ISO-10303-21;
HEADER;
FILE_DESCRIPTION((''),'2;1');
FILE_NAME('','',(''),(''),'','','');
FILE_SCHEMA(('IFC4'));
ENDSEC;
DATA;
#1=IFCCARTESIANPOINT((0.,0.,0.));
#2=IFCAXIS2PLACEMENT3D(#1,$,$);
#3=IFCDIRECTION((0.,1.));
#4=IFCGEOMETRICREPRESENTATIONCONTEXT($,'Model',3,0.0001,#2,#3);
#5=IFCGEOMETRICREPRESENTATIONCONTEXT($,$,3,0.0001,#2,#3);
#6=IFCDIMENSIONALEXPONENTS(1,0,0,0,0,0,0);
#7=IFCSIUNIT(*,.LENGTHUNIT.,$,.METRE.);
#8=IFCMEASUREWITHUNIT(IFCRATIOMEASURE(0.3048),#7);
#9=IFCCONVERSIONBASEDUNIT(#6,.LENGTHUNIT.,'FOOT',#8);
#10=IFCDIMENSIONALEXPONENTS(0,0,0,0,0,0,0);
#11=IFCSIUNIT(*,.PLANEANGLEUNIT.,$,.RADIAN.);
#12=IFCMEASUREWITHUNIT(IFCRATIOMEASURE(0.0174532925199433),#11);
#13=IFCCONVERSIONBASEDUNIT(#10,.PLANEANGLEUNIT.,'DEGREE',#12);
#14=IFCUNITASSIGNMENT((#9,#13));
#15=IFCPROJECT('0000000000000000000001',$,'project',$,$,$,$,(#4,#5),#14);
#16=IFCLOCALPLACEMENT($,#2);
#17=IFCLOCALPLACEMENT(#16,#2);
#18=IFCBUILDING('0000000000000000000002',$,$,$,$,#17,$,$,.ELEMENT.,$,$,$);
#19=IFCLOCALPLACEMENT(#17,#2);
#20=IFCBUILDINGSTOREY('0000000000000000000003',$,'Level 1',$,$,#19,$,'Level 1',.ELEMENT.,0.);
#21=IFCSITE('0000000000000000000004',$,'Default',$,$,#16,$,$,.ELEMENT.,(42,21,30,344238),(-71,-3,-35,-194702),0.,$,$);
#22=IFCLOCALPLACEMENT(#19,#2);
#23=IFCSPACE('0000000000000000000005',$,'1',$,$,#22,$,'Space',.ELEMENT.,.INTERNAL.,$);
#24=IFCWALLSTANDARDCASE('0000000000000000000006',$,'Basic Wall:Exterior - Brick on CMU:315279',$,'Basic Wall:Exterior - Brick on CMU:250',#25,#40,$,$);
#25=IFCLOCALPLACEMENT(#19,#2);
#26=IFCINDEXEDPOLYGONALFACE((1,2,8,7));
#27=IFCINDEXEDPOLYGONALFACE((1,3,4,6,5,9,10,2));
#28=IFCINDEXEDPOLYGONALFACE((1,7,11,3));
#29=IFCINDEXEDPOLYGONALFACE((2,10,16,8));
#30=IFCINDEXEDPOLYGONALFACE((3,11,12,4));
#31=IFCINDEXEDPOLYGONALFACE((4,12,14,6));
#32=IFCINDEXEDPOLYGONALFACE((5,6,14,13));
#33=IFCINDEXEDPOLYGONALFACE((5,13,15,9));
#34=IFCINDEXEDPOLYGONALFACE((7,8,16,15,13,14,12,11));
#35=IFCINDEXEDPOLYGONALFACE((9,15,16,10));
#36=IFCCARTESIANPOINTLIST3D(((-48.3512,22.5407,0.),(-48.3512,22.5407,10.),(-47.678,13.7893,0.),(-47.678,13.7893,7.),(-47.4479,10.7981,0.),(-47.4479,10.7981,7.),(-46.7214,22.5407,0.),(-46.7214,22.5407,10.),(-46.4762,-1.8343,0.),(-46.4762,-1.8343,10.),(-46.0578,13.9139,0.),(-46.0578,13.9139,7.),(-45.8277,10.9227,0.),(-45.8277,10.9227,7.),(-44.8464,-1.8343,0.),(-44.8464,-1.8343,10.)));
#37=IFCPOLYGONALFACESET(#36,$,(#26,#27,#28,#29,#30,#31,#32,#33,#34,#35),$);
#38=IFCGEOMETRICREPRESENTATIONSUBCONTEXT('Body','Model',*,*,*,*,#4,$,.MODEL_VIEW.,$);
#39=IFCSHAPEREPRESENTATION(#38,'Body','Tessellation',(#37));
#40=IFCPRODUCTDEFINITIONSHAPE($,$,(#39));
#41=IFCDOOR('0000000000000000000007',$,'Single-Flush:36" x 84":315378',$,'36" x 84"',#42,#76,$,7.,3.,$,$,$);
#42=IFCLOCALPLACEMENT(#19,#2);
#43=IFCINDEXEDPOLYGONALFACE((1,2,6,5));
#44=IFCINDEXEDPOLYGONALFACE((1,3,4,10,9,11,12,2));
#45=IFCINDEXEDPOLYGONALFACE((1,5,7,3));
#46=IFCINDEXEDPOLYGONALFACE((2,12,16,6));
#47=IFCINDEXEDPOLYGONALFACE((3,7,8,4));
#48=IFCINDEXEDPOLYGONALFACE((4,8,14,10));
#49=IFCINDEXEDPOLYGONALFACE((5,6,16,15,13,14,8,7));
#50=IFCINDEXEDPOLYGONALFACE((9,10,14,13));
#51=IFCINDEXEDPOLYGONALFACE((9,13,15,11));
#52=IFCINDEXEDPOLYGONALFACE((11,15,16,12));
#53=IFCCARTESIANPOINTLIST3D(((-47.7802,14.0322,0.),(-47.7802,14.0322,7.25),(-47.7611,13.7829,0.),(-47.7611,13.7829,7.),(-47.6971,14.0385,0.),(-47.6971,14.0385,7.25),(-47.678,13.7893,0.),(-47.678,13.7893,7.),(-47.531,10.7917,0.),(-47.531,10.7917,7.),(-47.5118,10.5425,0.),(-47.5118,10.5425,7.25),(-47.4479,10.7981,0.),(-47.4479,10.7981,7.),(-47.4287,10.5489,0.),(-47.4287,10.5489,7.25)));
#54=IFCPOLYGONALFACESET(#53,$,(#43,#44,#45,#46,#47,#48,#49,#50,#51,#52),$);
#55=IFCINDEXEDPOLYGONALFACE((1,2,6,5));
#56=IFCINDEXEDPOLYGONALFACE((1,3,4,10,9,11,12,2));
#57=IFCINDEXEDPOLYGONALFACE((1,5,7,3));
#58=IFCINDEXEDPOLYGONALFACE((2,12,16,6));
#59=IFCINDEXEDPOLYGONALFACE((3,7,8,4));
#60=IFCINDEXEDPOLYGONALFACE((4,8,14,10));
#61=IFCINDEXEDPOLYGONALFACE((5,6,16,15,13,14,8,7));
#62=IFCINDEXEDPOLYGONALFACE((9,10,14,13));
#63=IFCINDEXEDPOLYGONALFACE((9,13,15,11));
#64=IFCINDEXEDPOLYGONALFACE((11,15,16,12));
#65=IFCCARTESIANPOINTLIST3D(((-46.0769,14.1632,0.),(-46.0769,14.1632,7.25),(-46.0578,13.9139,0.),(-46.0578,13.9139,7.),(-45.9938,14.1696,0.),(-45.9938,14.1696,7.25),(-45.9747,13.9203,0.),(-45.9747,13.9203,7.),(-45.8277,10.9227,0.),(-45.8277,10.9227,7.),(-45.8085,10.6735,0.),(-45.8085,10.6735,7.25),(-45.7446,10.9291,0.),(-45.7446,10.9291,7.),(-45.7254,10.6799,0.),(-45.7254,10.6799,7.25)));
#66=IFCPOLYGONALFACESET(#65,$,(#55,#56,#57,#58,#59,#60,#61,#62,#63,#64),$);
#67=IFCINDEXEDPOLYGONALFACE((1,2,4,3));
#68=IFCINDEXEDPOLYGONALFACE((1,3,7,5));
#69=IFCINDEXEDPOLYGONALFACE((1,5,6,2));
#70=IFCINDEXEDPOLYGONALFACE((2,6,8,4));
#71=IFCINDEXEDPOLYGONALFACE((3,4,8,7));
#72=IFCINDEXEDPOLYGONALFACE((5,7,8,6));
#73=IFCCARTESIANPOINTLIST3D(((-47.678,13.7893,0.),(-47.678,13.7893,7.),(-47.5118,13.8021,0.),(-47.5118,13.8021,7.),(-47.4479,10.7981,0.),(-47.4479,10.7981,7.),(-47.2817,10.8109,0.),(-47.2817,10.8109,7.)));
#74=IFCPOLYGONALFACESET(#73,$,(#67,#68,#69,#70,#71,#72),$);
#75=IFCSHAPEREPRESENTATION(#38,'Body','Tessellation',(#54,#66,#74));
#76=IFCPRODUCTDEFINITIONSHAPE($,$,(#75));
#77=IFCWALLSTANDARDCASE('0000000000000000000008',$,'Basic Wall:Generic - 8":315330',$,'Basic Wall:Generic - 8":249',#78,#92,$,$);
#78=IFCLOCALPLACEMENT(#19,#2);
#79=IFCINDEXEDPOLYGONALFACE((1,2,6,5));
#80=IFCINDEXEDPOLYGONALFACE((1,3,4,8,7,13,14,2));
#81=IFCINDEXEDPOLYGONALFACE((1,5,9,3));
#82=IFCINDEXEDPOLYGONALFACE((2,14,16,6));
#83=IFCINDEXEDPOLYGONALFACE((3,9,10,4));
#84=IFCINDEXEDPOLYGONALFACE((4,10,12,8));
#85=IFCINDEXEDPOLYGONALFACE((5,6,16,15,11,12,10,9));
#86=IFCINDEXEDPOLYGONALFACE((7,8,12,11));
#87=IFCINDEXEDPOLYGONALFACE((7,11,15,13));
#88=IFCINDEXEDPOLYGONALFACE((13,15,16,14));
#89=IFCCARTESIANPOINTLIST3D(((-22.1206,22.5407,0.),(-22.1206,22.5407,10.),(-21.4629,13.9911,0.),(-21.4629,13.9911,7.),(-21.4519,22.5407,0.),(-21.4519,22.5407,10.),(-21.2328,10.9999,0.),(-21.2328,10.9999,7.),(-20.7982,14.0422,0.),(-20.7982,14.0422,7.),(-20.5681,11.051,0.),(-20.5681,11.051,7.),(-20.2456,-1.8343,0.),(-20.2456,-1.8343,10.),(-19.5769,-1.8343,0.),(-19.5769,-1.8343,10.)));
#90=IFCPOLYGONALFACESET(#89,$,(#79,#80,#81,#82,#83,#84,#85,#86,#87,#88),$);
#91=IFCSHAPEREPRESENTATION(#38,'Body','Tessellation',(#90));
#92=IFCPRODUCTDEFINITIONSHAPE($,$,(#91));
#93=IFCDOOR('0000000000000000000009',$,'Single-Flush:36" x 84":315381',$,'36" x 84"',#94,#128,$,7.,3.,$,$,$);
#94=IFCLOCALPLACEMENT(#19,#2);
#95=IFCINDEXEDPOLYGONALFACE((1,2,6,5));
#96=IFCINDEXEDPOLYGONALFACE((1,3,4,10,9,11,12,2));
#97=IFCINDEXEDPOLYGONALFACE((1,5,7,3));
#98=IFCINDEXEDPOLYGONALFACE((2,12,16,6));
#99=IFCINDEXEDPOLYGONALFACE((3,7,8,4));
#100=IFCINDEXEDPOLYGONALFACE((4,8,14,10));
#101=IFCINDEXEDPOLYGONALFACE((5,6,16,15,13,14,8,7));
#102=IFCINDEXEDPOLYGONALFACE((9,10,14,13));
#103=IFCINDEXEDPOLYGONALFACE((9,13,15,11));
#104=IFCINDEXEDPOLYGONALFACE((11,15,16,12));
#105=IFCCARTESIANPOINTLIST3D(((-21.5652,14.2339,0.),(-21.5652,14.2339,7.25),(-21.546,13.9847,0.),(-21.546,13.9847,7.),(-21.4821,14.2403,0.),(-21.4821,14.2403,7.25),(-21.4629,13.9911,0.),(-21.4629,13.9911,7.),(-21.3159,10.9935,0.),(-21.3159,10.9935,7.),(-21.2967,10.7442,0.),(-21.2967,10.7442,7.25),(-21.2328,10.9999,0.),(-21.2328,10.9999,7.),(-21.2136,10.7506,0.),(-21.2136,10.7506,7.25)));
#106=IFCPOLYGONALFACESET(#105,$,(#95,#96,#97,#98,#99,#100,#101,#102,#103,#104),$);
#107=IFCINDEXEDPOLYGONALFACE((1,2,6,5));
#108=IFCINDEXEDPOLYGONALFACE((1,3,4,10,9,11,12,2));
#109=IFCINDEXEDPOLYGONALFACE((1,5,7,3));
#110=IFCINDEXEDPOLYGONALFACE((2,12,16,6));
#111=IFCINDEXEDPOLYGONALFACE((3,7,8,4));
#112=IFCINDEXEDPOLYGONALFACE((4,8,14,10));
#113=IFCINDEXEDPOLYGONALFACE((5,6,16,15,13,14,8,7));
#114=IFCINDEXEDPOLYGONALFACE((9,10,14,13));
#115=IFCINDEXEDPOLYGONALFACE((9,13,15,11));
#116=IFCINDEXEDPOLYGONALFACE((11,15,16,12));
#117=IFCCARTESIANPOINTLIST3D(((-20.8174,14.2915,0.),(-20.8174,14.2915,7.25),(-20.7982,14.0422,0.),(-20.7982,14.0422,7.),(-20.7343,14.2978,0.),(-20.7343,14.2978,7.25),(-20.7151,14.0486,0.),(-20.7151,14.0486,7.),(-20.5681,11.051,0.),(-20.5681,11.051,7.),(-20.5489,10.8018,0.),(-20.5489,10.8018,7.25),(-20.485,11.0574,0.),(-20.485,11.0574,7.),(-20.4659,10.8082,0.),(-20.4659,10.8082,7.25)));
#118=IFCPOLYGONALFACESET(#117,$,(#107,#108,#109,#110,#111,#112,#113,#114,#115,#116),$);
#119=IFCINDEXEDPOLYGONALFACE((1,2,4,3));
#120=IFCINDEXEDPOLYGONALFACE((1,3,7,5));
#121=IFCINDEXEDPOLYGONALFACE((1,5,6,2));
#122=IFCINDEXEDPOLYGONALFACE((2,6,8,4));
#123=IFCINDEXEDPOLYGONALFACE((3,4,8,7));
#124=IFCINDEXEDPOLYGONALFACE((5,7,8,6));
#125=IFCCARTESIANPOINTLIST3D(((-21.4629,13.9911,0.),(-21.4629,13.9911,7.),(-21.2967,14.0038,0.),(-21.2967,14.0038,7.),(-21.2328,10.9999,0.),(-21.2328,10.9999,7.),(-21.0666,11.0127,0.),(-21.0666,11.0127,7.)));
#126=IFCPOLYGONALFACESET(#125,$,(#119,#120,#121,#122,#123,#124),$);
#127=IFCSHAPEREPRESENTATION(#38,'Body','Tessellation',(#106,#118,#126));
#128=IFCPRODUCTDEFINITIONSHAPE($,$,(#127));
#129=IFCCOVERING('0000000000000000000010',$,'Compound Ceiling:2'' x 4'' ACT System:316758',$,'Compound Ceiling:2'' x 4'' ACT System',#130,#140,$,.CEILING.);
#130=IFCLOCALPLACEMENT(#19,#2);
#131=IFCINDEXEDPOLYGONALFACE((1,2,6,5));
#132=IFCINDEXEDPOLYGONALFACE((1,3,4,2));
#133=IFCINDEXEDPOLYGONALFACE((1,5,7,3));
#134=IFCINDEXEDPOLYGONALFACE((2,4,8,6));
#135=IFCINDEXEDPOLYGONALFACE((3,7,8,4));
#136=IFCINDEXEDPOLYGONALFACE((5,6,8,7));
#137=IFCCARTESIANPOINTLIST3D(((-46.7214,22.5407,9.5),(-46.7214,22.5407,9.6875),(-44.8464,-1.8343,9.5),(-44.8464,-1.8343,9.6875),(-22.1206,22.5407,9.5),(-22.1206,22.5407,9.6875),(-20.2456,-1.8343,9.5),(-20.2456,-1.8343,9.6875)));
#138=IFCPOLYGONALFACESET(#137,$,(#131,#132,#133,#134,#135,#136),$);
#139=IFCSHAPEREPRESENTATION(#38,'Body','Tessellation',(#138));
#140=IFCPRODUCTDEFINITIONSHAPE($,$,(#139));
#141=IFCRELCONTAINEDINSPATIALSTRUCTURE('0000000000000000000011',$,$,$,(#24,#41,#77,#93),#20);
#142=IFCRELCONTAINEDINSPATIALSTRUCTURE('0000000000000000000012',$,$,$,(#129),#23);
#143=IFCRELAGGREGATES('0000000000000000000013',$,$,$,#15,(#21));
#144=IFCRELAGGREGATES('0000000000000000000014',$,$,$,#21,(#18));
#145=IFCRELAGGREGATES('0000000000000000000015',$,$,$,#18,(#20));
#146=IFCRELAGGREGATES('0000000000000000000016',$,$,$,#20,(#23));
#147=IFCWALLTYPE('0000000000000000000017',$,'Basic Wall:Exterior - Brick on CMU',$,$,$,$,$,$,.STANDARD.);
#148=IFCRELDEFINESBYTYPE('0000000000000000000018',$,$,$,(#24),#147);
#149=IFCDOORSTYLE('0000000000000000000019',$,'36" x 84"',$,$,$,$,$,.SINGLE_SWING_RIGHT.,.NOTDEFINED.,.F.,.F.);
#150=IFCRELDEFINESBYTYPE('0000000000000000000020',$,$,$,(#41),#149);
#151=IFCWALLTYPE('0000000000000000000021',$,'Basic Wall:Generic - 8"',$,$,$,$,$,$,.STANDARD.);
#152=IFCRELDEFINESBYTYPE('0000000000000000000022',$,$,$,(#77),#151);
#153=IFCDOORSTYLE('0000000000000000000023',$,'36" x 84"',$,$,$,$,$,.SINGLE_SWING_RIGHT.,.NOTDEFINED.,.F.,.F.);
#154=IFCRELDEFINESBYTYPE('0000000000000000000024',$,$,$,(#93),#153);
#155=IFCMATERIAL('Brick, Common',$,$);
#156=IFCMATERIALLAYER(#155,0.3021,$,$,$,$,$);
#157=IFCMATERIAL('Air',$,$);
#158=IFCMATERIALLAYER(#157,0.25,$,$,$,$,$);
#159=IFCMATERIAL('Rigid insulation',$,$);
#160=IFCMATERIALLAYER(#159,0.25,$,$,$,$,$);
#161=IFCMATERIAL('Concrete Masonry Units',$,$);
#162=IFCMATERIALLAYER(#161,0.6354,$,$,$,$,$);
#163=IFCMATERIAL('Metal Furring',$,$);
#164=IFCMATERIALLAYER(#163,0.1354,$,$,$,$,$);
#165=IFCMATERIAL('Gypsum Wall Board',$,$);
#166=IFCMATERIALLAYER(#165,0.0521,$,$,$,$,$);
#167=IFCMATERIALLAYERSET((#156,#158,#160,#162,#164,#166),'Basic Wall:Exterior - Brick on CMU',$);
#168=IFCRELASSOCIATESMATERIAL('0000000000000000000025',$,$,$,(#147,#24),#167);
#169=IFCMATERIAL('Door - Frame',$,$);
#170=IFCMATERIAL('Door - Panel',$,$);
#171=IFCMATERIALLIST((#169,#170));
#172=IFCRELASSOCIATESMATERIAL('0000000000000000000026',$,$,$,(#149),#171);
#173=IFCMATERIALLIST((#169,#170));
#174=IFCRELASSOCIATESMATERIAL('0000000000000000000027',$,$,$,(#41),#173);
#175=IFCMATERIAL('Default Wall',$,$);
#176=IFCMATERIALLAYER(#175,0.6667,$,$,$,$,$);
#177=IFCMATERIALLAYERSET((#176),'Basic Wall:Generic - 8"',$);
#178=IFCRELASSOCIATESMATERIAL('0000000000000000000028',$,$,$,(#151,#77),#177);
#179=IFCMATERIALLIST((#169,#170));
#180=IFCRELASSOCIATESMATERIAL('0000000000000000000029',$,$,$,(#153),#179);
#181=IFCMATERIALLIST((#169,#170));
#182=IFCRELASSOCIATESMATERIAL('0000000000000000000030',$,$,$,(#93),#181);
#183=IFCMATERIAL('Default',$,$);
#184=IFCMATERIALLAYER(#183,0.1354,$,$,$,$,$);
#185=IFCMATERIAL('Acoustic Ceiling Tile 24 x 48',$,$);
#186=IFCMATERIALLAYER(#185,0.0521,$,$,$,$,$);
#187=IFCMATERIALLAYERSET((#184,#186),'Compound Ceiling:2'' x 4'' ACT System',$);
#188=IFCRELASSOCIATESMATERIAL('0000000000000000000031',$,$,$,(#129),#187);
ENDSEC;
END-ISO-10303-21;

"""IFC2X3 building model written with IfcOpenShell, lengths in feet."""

from ifc_helpers import new_model, entity, si_unit, converted_unit, direction, frame, frame_2d, origin, place, context, subcontext, project, spatial, polyline, rectangle, outline, extrude, clip, bounded_halfspace, source, transform, mapped, material, material_list, layer, layer_set, layer_usage, type_object, type_shapes, element, fill, save


model = new_model("IFC2X3")

# Units and contexts
model_context = context("Model", 3, precision=0.0001, world=origin(), true_north=direction((0.0, 1.0)))
context_of_model = context(None, 3, precision=0.0001, world=origin(), true_north=direction((0.0, 1.0)))
body_context = subcontext(model_context, "Body", "Model", "MODEL_VIEW")
ifc_project = project(units=[converted_unit("LENGTHUNIT", "FOOT", entity("IfcRatioMeasure", 0.3048), si_unit("LENGTHUNIT", "METRE"), dimensions=[1, 0, 0, 0, 0, 0, 0]), converted_unit("PLANEANGLEUNIT", "DEGREE", entity("IfcRatioMeasure", 0.0174532925199433), si_unit("PLANEANGLEUNIT", "RADIAN"), dimensions=[0, 0, 0, 0, 0, 0, 0])], contexts=[model_context, context_of_model])

# Site, building, storey
site_placement = place(None, origin())
site = spatial("IfcSite", under=ifc_project, at=site_placement, Name="Default", CompositionType="ELEMENT", RefLatitude=(42, 21, 30, 344238), RefLongitude=(-71, -3, -35, -194702), RefElevation=0.0)
building_placement = place(site_placement, origin())
building = spatial("IfcBuilding", under=site, at=building_placement, CompositionType="ELEMENT")
storey_placement = place(building_placement, origin())
storey = spatial("IfcBuildingStorey", under=building, at=storey_placement, Name="Level 1", LongName="Level 1", CompositionType="ELEMENT", Elevation=0.0)

# Shared definitions
ifc_material_1 = material(Name="Brick, Common")
ifc_layer_1 = layer(ifc_material_1, 0.3021)
ifc_material_2 = material(Name="Air")
ifc_layer_2 = layer(ifc_material_2, 0.25)
ifc_material_3 = material(Name="Rigid insulation")
ifc_layer_3 = layer(ifc_material_3, 0.25)
ifc_material_4 = material(Name="Concrete Masonry Units")
ifc_layer_4 = layer(ifc_material_4, 0.6354)
ifc_material_5 = material(Name="Metal Furring")
ifc_layer_5 = layer(ifc_material_5, 0.1354)
ifc_material_6 = material(Name="Gypsum Wall Board")
ifc_layer_6 = layer(ifc_material_6, 0.0521)
ifc_layer_set_1 = layer_set([ifc_layer_1, ifc_layer_2, ifc_layer_3, ifc_layer_4, ifc_layer_5, ifc_layer_6], Name="Basic Wall:Exterior - Brick on CMU")
wall_type_1 = type_object("IfcWallType", Name="Basic Wall:Exterior - Brick on CMU", PredefinedType="STANDARD", material=ifc_layer_set_1)
ifc_material_7 = material(Name="Door - Frame")
ifc_material_8 = material(Name="Door - Panel")
ifc_material_list_1 = material_list([ifc_material_7, ifc_material_8])
door_style_1 = type_object("IfcDoorStyle", Name="36\" x 84\"", ConstructionType="NOTDEFINED", OperationType="SINGLE_SWING_RIGHT", ParameterTakesPrecedence=False, Sizeable=False, material=ifc_material_list_1)
shared_shape_1 = source(origin(), body_context, "Body", "SweptSolid", [
    extrude(outline(polyline([(-1.75, -3.6875), (1.75, -3.6875), (1.75, 3.5625), (1.5, 3.5625), (1.5, -3.4375), (-1.5, -3.4375), (-1.5, 3.5625), (-1.75, 3.5625), (-1.75, -3.6875)])), frame((1.5, 1.625, 3.5625), z_axis=(0.0, 1.0, 0.0), x_axis=(1.0, 0.0, 0.0)), (0.0, 0.0, 1.0), 0.0833),
    extrude(outline(polyline([(-3.6875, -1.75), (3.5625, -1.75), (3.5625, -1.5), (-3.4375, -1.5), (-3.4375, 1.5), (3.5625, 1.5), (3.5625, 1.75), (-3.6875, 1.75), (-3.6875, -1.75)])), frame((1.5, -0.0833, 3.5625), z_axis=(0.0, 1.0, 0.0), x_axis=(0.0, 0.0, -1.0)), (0.0, 0.0, 1.0), 0.0833),
    extrude(rectangle(XDim=0.1667, YDim=3.0, at=frame_2d((0.0, 0.0), x_axis=(1.0, 0.0))), frame((1.5, 1.5417, 0.0), z_axis=(0.0, 0.0, 1.0), x_axis=(0.0, 1.0, 0.0)), (0.0, 0.0, 1.0), 7.0),
])
type_shapes(door_style_1, [shared_shape_1])

# Walls, openings, doors
ifc_layer_usage_1 = layer_usage(ifc_layer_set_1, "AXIS2", "NEGATIVE", 0.8125)
wall_1_placement = place(storey_placement, frame((-45.6565, -1.8966, 0.0), z_axis=(0.0, 0.0, 1.0), x_axis=(-0.076696, 0.997054, 0.0)))
wall_1 = element("IfcWallStandardCase", 1, at=wall_1_placement, inside=storey, type_object=wall_type_1, material=ifc_layer_usage_1, Name="Basic Wall:Exterior - Brick on CMU:315279", ObjectType="Basic Wall:Exterior - Brick on CMU:250", context=body_context, shape_type="Clipping", body=[
    clip(extrude(outline(polyline([(0.0, -0.8125), (24.447, -0.8125), (24.572, 0.8125), (0.125, 0.8125), (0.0, -0.8125)])), origin(), (0.0, 0.0, 1.0), 10.0), bounded_halfspace(frame((0.0, -0.8125, 10.0), z_axis=(0.0, 0.0, 1.0), x_axis=(-0.076696, -0.997054, 0.0)), False, frame((0.0, -0.8125, 10.0)), polyline([(0.0, 0.0), (24.447, 0.0), (24.572, 1.625), (0.125, 1.625), (0.0, 0.0)]))),
])
opening_1_placement = place(wall_1_placement, frame((12.7947, -0.8125, 0.0)))
opening_1 = element("IfcOpeningElement", 2, at=opening_1_placement, cuts=wall_1, ObjectType="Opening", context=body_context, shape_type="SweptSolid", body=[
    extrude(rectangle(XDim=3.0, YDim=7.0, at=frame_2d((3.5, 1.5), x_axis=(0.0, 1.0))), frame((0.0, 0.0, 0.0), z_axis=(0.0, 1.0, 0.0), x_axis=(0.0, 0.0, 1.0)), (0.0, 0.0, 1.0), 1.625),
])
ifc_material_list_2 = material_list([ifc_material_7, ifc_material_8])
door_1_placement = place(opening_1_placement, origin())
door_1 = element("IfcDoor", 3, at=door_1_placement, inside=storey, type_object=door_style_1, material=ifc_material_list_2, Name="Single-Flush:36\" x 84\":315378", ObjectType="36\" x 84\"", OverallHeight=7.0, OverallWidth=3.0, context=body_context, shape_type="MappedRepresentation", body=[
    mapped(shared_shape_1, transform((0.0, 0.0, 0.0), scale=1.0)),
])
fill(opening_1, door_1)
ifc_material_9 = material(Name="Default Wall")
ifc_layer_7 = layer(ifc_material_9, 0.6667)
ifc_layer_set_2 = layer_set([ifc_layer_7], Name="Basic Wall:Generic - 8\"")
ifc_layer_usage_2 = layer_usage(ifc_layer_set_2, "AXIS2", "NEGATIVE", 0.3333)
wall_type_2 = type_object("IfcWallType", Name="Basic Wall:Generic - 8\"", PredefinedType="STANDARD", material=ifc_layer_set_2)
wall_2_placement = place(storey_placement, frame((-21.7882, 22.5663, 0.0), z_axis=(0.0, 0.0, 1.0), x_axis=(0.076696, -0.997054, 0.0)))
wall_2 = element("IfcWallStandardCase", 4, at=wall_2_placement, inside=storey, type_object=wall_type_2, material=ifc_layer_usage_2, Name="Basic Wall:Generic - 8\":315330", ObjectType="Basic Wall:Generic - 8\":249", context=body_context, shape_type="Clipping", body=[
    clip(extrude(outline(polyline([(0.0, -0.3333), (24.447, -0.3333), (24.4983, 0.3333), (0.0513, 0.3333), (0.0, -0.3333)])), origin(), (0.0, 0.0, 1.0), 10.0), bounded_halfspace(frame((0.0, -0.3333, 10.0), z_axis=(0.0, 0.0, 1.0), x_axis=(0.076696, 0.997054, 0.0)), False, frame((0.0, -0.3333, 10.0)), polyline([(0.0, 0.0), (24.447, 0.0), (24.4983, 0.6667), (0.0513, 0.6667), (0.0, 0.0)]))),
])
opening_2_placement = place(wall_2_placement, frame((11.5749, 0.3333, 0.0)))
opening_2 = element("IfcOpeningElement", 5, at=opening_2_placement, cuts=wall_2, ObjectType="Opening", context=body_context, shape_type="SweptSolid", body=[
    extrude(rectangle(XDim=3.0, YDim=7.0, at=frame_2d((3.5, 1.5), x_axis=(0.0, 1.0))), frame((0.0, 0.0, 0.0), z_axis=(0.0, -1.0, 0.0), x_axis=(0.0, 0.0, 1.0)), (0.0, 0.0, 1.0), 0.6667),
])
ifc_material_list_3 = material_list([ifc_material_7, ifc_material_8])
ifc_material_list_4 = material_list([ifc_material_7, ifc_material_8])
door_style_2 = type_object("IfcDoorStyle", Name="36\" x 84\"", ConstructionType="NOTDEFINED", OperationType="SINGLE_SWING_RIGHT", ParameterTakesPrecedence=False, Sizeable=False, material=ifc_material_list_4)
shared_shape_2 = source(origin(), body_context, "Body", "SweptSolid", [
    extrude(outline(polyline([(-1.75, -3.6875), (1.75, -3.6875), (1.75, 3.5625), (1.5, 3.5625), (1.5, -3.4375), (-1.5, -3.4375), (-1.5, 3.5625), (-1.75, 3.5625), (-1.75, -3.6875)])), frame((1.5, 0.6667, 3.5625), z_axis=(0.0, 1.0, 0.0), x_axis=(1.0, 0.0, 0.0)), (0.0, 0.0, 1.0), 0.0833),
    extrude(outline(polyline([(-3.6875, -1.75), (3.5625, -1.75), (3.5625, -1.5), (-3.4375, -1.5), (-3.4375, 1.5), (3.5625, 1.5), (3.5625, 1.75), (-3.6875, 1.75), (-3.6875, -1.75)])), frame((1.5, -0.0833, 3.5625), z_axis=(0.0, 1.0, 0.0), x_axis=(0.0, 0.0, -1.0)), (0.0, 0.0, 1.0), 0.0833),
    extrude(rectangle(XDim=0.1667, YDim=3.0, at=frame_2d((0.0, 0.0), x_axis=(1.0, 0.0))), frame((1.5, 0.5833, 0.0), z_axis=(0.0, 0.0, 1.0), x_axis=(0.0, 1.0, 0.0)), (0.0, 0.0, 1.0), 7.0),
])
type_shapes(door_style_2, [shared_shape_2])
door_2_placement = place(opening_2_placement, frame((0.0, 0.0, 0.0), z_axis=(0.0, 0.0, 1.0), x_axis=(-1.0, 0.0, 0.0)))
door_2 = element("IfcDoor", 6, at=door_2_placement, inside=storey, type_object=door_style_2, material=ifc_material_list_3, Name="Single-Flush:36\" x 84\":315381", ObjectType="36\" x 84\"", OverallHeight=7.0, OverallWidth=3.0, context=body_context, shape_type="MappedRepresentation", body=[
    mapped(shared_shape_2, transform((0.0, 0.0, 0.0), scale=1.0)),
])
fill(opening_2, door_2)

# Shared definitions
ifc_material_10 = material(Name="Default")
ifc_layer_8 = layer(ifc_material_10, 0.1354)
ifc_material_11 = material(Name="Acoustic Ceiling Tile 24 x 48")
ifc_layer_9 = layer(ifc_material_11, 0.0521)
ifc_layer_set_3 = layer_set([ifc_layer_8, ifc_layer_9], Name="Compound Ceiling:2' x 4' ACT System")

# Shared definitions
space_placement = place(storey_placement, origin())
space = spatial("IfcSpace", under=storey, at=space_placement, Name="1", LongName="Space", CompositionType="ELEMENT", InteriorOrExteriorSpace="INTERNAL")

# Covering
ifc_layer_usage_3 = layer_usage(ifc_layer_set_3, "AXIS3", "NEGATIVE", 0.0)
covering_1_placement = place(space_placement, origin())
element("IfcCovering", 7, at=covering_1_placement, inside=space, material=ifc_layer_usage_3, Name="Compound Ceiling:2' x 4' ACT System:316758", ObjectType="Compound Ceiling:2' x 4' ACT System", PredefinedType="CEILING", context=body_context, shape_type="SweptSolid", body=[
    extrude(outline(polyline([(-13.1669, -12.2642), (11.2801, -12.2642), (13.1669, 12.2642), (-11.2801, 12.2642), (-13.1669, -12.2642)])), frame((-33.4835, 10.3532, 9.5), z_axis=(0.0, 0.0, 1.0), x_axis=(0.076696, -0.997054, 0.0)), (0.0, 0.0, 1.0), 0.1875),
])

save(model, "model.ifc")
